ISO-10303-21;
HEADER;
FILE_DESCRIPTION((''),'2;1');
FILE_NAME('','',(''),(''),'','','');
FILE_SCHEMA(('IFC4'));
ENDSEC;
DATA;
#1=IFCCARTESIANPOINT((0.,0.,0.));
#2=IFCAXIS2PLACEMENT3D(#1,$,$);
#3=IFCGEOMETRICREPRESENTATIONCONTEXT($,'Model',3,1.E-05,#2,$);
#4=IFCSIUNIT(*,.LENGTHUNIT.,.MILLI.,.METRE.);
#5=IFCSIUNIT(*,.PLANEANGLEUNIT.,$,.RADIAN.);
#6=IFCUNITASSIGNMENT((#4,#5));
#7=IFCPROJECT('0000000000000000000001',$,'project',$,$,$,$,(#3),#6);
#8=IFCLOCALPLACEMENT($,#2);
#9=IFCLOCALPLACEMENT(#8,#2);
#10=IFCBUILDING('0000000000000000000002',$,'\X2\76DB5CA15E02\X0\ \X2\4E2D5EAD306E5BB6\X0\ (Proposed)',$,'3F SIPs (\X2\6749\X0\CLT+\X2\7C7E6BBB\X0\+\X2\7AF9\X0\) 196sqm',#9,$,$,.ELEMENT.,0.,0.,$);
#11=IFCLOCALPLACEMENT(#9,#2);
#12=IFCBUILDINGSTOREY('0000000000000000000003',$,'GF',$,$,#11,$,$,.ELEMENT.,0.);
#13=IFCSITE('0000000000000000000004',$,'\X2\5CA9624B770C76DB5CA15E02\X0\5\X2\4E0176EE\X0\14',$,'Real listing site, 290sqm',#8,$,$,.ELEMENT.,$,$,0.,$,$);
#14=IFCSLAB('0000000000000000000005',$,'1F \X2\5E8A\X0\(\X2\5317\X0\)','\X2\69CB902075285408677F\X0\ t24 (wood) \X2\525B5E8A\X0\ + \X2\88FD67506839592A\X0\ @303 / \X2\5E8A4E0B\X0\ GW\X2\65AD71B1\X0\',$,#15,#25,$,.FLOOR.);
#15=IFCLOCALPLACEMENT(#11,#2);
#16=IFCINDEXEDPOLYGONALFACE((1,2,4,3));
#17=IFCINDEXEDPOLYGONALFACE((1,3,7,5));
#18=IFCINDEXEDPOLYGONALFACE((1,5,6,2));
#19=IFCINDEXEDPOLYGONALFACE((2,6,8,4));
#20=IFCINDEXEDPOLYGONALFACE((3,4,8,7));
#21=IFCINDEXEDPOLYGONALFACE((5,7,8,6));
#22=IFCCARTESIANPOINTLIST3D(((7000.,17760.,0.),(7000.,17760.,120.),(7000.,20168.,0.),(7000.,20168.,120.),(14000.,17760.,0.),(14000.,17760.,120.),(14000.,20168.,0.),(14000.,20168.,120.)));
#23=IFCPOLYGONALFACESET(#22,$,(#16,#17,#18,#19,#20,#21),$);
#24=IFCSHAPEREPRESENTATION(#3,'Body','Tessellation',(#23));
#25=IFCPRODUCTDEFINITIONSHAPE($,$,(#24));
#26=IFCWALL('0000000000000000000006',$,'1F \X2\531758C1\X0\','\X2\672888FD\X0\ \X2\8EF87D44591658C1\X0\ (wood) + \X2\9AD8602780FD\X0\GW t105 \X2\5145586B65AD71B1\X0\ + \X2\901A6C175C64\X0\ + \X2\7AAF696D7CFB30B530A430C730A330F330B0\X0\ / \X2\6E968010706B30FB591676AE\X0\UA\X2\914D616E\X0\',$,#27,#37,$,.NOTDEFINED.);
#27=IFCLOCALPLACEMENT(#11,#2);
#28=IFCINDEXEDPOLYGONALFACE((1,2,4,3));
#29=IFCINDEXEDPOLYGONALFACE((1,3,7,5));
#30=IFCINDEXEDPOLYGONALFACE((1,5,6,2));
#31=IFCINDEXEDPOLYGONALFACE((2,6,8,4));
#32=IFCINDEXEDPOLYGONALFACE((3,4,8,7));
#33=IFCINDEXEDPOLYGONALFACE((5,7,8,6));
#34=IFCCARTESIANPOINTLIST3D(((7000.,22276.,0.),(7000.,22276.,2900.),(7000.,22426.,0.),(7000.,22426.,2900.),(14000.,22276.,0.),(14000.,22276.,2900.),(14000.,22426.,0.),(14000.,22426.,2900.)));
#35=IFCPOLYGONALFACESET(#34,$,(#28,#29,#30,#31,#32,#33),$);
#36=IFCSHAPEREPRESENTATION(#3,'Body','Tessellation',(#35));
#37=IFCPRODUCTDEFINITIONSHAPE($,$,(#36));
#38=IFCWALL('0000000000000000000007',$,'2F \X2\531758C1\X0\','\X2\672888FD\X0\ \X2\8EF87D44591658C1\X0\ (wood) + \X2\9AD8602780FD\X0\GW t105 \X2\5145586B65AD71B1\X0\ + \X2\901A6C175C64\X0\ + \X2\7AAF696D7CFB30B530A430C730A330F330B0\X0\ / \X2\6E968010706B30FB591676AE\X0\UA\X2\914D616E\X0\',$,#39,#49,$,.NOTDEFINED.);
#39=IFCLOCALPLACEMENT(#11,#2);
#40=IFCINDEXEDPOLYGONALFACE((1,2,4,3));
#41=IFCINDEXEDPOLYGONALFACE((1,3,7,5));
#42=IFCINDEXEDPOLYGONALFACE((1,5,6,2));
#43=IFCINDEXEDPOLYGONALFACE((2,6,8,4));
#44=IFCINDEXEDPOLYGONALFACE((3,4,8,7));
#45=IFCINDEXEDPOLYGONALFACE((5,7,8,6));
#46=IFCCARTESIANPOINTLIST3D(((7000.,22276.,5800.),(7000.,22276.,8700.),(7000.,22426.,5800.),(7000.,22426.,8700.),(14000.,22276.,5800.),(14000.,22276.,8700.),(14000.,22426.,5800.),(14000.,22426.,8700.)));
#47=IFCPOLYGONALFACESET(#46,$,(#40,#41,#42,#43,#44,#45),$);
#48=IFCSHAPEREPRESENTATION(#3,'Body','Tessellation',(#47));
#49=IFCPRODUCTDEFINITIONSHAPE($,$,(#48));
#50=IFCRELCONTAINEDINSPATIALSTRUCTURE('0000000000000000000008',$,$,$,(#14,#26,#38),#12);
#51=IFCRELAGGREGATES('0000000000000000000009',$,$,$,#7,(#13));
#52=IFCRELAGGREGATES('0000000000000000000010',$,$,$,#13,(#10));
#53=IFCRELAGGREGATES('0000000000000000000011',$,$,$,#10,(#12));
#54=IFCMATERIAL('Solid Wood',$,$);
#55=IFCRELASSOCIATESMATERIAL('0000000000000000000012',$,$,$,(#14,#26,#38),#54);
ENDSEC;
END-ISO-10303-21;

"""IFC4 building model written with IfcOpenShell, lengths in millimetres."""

from ifc_helpers import new_model, si_unit, frame, frame_2d, origin, place, context, project, spatial, rectangle, extrude, material, element, save


model = new_model("IFC4")

# Units and contexts
model_context = context("Model", 3, precision=1e-05, world=origin())
ifc_project = project(units=[si_unit("LENGTHUNIT", "METRE", prefix="MILLI"), si_unit("PLANEANGLEUNIT", "RADIAN")], contexts=[model_context])

# Site, building, storey
site_placement = place(None, origin())
site = spatial("IfcSite", under=ifc_project, at=site_placement, Name="岩手県盛岡市5丁目14", ObjectType="Real listing site, 290sqm", CompositionType="ELEMENT", RefElevation=0.0)
building_placement = place(site_placement, origin())
building = spatial("IfcBuilding", under=site, at=building_placement, Name="盛岡市 中庭の家 (Proposed)", ObjectType="3F SIPs (杉CLT+籾殻+竹) 196sqm", CompositionType="ELEMENT", ElevationOfRefHeight=0.0, ElevationOfTerrain=0.0)
storey_placement = place(building_placement, origin())
storey = spatial("IfcBuildingStorey", under=building, at=storey_placement, Name="GF", CompositionType="ELEMENT", Elevation=0.0)

# Slab
ifc_material_1 = material(Name="Solid Wood")
slab_1_placement = place(storey_placement, frame((3500.0, 8880.0, 0.0)))
element("IfcSlab", 1, at=slab_1_placement, inside=storey, material=ifc_material_1, Name="1F 床(北)", Description="構造用合板 t24 (wood) 剛床 + 製材根太 @303 / 床下 GW断熱", PredefinedType="FLOOR", context=model_context, shape_type="SweptSolid", body=[
    extrude(rectangle(XDim=7000.0, YDim=2408.0, at=frame_2d((3500.0, 1204.0))), frame((3500.0, 8880.0, 0.0)), (0.0, 0.0, 1.0), 120.0),
])

# Wall
wall_1_placement = place(storey_placement, frame((3500.0, 11138.0, 0.0)))
element("IfcWall", 2, at=wall_1_placement, inside=storey, material=ifc_material_1, Name="1F 北壁", Description="木製 軸組外壁 (wood) + 高性能GW t105 充填断熱 + 通気層 + 窯業系サイディング / 準耐火・外皮UA配慮", PredefinedType="NOTDEFINED", context=model_context, shape_type="SweptSolid", body=[
    extrude(rectangle(XDim=7000.0, YDim=150.0, at=frame_2d((3500.0, 75.0))), frame((3500.0, 11138.0, 0.0)), (0.0, 0.0, 1.0), 2900.0),
])

# Wall
wall_2_placement = place(storey_placement, frame((3500.0, 11138.0, 2900.0)))
element("IfcWall", 3, at=wall_2_placement, inside=storey, material=ifc_material_1, Name="2F 北壁", Description="木製 軸組外壁 (wood) + 高性能GW t105 充填断熱 + 通気層 + 窯業系サイディング / 準耐火・外皮UA配慮", PredefinedType="NOTDEFINED", context=model_context, shape_type="SweptSolid", body=[
    extrude(rectangle(XDim=7000.0, YDim=150.0, at=frame_2d((3500.0, 75.0))), frame((3500.0, 11138.0, 2900.0)), (0.0, 0.0, 1.0), 2900.0),
])

save(model, "model.ifc")
